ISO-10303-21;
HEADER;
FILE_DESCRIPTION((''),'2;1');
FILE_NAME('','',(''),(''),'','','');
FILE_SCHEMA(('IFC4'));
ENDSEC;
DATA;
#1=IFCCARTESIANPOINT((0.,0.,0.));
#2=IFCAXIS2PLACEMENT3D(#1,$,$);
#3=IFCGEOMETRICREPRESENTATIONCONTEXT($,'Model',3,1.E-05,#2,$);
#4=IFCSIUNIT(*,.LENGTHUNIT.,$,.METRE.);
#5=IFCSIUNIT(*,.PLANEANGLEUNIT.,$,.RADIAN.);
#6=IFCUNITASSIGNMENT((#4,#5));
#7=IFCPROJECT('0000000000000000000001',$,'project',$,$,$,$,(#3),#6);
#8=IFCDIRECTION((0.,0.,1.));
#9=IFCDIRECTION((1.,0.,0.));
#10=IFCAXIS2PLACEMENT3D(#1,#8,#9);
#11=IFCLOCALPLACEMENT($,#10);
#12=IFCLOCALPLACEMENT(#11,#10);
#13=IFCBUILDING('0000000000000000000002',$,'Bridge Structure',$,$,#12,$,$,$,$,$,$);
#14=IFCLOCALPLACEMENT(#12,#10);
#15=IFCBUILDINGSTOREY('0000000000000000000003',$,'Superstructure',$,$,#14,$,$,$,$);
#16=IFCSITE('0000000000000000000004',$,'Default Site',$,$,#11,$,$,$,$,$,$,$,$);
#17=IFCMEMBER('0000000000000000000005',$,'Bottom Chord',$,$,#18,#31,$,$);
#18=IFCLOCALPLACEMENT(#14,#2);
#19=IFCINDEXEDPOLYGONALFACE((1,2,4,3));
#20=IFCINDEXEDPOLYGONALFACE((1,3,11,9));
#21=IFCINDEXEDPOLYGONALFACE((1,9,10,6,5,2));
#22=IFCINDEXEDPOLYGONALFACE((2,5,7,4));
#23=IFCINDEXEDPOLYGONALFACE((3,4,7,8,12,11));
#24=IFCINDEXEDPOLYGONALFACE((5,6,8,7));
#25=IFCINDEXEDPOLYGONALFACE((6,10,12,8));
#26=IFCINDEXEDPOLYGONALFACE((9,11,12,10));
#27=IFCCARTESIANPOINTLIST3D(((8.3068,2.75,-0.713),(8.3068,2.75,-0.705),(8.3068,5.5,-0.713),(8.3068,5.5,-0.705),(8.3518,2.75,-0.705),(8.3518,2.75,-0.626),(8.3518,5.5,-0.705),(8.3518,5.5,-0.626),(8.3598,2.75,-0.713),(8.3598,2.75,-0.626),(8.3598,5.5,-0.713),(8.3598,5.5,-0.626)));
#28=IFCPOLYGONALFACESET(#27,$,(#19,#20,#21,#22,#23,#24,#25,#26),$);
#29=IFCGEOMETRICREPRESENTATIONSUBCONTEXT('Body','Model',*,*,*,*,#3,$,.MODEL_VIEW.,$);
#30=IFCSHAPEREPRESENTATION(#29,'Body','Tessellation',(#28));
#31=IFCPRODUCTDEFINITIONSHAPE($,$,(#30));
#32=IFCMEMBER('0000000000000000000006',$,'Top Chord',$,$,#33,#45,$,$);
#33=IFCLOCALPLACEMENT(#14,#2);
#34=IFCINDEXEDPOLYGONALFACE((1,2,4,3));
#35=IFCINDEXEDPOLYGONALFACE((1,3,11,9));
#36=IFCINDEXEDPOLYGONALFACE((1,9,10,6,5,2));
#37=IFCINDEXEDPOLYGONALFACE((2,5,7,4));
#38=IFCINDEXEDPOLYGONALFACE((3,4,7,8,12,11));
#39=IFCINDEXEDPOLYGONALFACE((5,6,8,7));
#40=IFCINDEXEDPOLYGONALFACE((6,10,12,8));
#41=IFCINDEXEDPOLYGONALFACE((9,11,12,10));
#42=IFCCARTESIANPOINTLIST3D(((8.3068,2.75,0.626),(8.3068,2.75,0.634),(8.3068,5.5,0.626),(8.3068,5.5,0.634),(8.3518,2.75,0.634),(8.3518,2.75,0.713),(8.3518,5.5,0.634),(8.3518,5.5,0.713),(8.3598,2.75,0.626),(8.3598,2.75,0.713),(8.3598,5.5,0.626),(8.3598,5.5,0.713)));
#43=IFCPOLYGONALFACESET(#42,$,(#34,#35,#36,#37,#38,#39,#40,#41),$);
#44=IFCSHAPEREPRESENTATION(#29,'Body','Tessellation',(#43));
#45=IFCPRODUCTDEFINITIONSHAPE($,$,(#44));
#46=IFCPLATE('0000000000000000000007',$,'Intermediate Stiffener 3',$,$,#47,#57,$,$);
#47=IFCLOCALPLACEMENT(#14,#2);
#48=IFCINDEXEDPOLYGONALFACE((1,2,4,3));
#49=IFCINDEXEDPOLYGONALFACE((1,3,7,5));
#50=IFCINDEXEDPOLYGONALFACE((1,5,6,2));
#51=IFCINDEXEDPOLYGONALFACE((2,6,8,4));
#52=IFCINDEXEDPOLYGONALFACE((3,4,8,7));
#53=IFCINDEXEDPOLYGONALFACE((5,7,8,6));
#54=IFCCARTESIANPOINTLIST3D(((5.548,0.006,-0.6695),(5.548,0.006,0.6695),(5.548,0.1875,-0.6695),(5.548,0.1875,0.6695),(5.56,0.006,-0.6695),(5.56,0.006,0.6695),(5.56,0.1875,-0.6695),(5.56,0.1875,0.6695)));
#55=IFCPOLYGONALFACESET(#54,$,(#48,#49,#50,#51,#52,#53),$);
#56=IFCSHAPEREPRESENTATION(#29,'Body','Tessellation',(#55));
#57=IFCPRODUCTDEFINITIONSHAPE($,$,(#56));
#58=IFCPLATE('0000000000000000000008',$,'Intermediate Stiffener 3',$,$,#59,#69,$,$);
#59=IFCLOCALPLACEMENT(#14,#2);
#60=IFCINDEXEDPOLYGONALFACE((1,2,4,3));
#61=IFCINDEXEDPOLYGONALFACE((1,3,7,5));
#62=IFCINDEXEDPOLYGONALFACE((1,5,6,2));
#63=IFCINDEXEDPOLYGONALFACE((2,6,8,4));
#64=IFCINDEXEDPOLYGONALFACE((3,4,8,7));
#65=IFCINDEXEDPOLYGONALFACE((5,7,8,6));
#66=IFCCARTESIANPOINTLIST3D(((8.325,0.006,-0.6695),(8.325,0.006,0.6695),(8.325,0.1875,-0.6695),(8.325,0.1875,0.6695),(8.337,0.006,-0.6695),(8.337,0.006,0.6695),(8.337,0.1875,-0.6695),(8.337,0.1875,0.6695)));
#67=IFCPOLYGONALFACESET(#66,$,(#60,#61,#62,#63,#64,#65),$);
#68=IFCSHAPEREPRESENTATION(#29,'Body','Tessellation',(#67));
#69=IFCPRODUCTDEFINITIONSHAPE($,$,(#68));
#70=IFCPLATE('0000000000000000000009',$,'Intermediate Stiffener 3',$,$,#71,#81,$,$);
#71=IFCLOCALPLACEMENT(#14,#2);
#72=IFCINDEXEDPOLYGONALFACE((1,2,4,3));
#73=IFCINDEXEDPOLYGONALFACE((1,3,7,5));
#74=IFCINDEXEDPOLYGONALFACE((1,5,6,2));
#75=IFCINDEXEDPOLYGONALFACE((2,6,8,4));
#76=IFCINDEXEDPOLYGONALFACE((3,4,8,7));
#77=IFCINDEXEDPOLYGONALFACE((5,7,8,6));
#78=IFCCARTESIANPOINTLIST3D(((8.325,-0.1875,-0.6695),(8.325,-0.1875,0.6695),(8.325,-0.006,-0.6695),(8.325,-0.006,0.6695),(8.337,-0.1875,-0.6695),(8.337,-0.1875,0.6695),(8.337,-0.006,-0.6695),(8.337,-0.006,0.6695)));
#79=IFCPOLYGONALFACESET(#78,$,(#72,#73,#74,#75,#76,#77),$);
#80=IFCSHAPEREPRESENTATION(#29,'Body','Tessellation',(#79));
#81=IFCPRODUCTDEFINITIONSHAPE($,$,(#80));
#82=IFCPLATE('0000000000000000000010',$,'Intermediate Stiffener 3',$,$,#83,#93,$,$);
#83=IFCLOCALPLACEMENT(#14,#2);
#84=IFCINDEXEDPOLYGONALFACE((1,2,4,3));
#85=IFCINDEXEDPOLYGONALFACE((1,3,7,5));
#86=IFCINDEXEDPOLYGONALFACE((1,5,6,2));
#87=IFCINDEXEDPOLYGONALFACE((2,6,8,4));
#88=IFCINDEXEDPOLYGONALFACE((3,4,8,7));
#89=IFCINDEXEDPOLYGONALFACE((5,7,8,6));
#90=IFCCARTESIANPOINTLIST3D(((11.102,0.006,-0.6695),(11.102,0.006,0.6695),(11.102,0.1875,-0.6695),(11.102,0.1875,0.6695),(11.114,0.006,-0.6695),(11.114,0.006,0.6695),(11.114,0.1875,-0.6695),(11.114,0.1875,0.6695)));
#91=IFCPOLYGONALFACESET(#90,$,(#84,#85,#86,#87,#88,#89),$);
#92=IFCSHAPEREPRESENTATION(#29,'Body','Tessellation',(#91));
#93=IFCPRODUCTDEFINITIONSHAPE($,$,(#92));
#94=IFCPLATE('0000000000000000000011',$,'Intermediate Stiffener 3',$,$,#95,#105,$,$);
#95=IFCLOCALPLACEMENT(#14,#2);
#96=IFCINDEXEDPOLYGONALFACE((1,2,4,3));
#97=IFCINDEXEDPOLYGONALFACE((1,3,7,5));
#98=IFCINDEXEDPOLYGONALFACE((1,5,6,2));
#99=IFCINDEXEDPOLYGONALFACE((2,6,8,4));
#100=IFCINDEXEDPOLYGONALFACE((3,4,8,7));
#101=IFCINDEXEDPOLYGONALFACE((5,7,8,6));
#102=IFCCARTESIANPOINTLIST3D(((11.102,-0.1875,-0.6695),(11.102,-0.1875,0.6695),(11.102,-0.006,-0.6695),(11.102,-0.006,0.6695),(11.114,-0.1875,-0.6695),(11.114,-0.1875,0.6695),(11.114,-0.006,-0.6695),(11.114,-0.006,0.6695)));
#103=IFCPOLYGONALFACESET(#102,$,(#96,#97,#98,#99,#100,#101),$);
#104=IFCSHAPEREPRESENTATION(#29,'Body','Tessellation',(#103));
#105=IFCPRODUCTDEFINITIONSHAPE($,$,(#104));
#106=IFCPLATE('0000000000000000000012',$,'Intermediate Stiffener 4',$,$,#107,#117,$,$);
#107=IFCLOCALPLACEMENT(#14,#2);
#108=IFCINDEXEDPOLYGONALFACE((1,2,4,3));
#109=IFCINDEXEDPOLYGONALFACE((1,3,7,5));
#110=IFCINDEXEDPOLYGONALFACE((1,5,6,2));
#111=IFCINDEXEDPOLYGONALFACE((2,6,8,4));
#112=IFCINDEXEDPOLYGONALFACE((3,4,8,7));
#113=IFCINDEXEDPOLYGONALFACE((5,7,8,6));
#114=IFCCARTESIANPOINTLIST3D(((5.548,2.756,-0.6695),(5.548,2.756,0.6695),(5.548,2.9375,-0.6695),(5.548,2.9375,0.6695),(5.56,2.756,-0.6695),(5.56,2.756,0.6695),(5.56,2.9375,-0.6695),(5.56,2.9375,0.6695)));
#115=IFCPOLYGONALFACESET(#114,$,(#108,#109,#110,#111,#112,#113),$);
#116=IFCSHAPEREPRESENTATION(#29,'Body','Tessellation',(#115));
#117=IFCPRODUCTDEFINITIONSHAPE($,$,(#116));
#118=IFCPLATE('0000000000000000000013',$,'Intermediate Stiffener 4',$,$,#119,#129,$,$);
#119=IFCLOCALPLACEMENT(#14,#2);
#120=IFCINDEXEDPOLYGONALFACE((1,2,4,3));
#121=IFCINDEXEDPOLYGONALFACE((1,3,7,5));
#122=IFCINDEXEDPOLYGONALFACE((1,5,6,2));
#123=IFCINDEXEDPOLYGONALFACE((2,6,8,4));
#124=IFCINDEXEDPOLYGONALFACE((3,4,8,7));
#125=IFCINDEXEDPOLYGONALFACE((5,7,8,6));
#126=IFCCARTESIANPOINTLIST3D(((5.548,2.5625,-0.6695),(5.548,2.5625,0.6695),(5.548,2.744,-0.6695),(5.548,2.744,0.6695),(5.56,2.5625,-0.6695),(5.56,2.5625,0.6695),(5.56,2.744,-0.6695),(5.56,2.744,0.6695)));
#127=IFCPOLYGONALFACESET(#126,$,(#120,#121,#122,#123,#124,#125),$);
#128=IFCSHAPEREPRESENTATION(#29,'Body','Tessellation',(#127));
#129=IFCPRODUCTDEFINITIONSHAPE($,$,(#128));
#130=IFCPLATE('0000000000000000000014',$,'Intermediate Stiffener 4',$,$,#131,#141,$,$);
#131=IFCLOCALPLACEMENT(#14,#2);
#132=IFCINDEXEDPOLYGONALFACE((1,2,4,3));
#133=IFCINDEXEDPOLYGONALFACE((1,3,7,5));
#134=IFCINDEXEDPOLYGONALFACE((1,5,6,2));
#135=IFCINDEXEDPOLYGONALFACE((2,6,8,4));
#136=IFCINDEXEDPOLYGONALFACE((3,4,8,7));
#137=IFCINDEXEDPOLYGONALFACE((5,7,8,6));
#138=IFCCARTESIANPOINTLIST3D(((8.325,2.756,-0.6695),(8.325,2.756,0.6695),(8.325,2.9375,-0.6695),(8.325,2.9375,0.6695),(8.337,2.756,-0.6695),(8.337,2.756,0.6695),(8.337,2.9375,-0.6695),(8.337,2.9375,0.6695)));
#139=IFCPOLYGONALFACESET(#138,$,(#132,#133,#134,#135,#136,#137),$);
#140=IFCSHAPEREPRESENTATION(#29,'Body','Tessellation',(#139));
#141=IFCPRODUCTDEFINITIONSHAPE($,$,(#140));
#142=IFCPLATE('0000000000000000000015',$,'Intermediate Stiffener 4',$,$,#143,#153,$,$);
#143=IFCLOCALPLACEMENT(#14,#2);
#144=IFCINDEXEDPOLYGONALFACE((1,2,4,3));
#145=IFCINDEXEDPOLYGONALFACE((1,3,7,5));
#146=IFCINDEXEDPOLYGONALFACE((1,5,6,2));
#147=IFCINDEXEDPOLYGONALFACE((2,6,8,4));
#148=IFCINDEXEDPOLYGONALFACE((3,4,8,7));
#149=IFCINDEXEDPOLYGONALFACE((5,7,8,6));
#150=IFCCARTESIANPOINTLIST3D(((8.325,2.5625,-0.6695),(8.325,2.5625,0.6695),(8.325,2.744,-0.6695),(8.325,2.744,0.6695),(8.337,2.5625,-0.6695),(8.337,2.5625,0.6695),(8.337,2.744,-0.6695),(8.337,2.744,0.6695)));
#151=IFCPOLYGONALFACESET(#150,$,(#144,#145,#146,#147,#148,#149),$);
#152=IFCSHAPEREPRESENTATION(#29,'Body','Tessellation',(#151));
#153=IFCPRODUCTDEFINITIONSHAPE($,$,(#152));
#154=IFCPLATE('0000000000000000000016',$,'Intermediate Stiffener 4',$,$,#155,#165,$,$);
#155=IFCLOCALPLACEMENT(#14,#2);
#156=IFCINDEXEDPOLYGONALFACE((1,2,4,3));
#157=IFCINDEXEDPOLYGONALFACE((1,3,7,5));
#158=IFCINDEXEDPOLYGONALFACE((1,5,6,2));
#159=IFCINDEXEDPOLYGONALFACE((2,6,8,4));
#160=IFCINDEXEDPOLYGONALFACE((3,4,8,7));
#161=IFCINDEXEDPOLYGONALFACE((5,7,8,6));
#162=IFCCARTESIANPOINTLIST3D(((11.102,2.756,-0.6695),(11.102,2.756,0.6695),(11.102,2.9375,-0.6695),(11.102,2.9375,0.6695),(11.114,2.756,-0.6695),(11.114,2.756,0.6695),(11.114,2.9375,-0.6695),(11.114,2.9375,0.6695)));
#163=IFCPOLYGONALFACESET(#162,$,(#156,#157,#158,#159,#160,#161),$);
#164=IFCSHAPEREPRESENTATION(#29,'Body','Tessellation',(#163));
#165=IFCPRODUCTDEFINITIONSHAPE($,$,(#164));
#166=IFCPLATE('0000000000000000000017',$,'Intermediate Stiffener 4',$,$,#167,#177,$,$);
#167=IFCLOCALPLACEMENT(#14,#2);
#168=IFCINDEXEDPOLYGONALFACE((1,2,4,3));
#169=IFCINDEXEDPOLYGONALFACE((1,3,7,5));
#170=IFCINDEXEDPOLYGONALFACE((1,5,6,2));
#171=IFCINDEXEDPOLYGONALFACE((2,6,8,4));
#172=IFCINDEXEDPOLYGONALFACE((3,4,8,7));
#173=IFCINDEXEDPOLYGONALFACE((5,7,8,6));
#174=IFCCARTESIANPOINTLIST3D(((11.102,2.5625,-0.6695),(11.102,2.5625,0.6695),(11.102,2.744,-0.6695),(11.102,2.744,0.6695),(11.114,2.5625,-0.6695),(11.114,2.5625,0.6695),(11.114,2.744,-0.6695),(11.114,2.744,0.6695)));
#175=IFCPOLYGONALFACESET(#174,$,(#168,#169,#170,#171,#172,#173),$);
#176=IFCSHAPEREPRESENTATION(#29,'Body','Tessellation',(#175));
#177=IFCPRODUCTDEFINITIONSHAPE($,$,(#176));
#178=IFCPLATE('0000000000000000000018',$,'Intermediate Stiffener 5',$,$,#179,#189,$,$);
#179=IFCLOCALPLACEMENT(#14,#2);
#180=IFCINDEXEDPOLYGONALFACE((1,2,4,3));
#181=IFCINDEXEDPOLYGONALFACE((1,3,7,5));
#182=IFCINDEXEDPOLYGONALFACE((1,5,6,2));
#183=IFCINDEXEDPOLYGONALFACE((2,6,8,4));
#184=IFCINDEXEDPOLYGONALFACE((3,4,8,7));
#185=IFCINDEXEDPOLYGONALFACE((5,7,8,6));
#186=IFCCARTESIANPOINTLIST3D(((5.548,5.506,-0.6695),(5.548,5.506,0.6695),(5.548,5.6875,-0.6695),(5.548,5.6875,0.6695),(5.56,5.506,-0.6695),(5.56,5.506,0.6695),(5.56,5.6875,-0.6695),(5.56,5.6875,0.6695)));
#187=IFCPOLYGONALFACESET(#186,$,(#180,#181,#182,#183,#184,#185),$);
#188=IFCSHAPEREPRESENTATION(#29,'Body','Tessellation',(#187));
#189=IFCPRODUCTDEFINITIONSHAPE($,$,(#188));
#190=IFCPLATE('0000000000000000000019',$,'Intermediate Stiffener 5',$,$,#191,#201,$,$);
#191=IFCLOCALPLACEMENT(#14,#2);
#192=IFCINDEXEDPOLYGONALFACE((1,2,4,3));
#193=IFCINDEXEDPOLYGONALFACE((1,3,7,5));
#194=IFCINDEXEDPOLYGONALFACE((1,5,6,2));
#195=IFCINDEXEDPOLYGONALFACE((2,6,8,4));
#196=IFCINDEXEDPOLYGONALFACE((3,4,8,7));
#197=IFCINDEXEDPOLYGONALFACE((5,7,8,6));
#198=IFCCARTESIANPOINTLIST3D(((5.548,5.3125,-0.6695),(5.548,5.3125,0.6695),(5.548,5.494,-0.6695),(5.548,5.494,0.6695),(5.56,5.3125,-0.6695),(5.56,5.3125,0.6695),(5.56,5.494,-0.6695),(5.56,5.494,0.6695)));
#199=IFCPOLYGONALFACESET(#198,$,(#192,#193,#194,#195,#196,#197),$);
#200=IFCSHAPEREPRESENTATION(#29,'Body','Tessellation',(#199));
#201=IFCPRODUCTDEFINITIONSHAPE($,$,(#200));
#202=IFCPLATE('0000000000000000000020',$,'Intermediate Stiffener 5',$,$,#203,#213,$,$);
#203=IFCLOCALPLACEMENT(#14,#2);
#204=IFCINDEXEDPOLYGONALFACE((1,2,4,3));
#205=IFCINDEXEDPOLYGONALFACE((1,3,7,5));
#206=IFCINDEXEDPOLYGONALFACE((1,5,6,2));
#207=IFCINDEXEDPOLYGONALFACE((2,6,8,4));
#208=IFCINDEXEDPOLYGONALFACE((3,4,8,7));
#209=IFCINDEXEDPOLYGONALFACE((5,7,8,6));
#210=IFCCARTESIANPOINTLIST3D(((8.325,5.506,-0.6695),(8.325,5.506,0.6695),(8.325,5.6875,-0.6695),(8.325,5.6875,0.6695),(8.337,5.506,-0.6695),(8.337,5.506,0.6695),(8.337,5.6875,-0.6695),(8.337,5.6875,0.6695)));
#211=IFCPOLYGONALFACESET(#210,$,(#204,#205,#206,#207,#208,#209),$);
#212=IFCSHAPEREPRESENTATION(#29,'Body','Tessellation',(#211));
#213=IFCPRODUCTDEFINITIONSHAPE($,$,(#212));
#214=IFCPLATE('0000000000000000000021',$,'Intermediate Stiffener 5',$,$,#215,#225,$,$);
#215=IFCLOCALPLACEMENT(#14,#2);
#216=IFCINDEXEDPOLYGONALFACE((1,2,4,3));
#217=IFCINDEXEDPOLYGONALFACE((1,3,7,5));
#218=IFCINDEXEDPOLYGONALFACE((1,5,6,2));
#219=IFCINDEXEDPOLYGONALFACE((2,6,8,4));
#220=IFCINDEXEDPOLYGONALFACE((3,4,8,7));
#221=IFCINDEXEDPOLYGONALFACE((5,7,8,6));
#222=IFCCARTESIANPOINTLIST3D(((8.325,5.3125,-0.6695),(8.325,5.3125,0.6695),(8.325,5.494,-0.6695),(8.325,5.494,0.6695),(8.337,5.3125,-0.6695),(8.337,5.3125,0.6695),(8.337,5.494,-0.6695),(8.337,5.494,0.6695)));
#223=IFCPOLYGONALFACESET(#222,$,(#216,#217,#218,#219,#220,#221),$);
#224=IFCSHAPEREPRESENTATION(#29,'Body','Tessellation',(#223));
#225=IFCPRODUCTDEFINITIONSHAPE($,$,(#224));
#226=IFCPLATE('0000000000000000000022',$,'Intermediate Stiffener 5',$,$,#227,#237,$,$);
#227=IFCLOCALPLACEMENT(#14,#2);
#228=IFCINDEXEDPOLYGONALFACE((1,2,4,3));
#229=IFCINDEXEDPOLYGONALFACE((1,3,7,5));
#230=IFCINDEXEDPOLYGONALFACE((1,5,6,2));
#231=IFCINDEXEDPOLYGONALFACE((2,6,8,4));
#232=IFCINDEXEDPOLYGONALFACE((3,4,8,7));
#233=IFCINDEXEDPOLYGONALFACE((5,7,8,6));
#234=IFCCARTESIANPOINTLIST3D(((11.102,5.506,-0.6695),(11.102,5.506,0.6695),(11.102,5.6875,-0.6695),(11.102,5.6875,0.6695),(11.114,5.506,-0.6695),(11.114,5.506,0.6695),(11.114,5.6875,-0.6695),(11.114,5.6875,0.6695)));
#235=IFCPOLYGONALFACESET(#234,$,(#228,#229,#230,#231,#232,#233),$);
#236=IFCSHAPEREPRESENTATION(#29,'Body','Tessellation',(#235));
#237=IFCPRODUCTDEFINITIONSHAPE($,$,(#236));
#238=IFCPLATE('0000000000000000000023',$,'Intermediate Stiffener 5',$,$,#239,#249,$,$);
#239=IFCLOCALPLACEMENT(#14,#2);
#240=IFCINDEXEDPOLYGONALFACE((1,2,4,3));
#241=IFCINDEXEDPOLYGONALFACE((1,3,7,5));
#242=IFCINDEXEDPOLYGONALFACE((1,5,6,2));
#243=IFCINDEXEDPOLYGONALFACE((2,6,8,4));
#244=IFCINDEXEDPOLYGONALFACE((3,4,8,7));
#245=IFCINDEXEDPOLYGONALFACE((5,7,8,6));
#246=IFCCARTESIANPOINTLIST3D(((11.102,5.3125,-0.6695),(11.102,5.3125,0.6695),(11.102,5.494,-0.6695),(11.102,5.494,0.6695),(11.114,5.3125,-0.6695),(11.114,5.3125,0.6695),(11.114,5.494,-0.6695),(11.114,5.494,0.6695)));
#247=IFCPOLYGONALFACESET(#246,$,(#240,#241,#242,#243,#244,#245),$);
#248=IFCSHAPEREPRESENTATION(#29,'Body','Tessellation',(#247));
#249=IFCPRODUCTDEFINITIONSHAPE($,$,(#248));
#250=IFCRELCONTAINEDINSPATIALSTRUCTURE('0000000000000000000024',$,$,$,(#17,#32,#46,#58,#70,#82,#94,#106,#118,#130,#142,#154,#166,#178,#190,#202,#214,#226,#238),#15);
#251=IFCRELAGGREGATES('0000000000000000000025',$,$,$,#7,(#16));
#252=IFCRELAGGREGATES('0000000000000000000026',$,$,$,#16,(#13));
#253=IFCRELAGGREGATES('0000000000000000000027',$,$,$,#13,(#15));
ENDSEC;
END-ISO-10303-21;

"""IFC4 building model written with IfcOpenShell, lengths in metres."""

from ifc_helpers import new_model, si_unit, frame, origin, origin_with_axes, origin_2d_with_axis, place, context, subcontext, project, spatial, rectangle, l_section, extrude, element, save


model = new_model("IFC4")

# Units and contexts
model_context = context("Model", 3, precision=1e-05, world=origin())
body_context = subcontext(model_context, "Body", "Model", "MODEL_VIEW")
ifc_project = project(units=[si_unit("LENGTHUNIT", "METRE"), si_unit("PLANEANGLEUNIT", "RADIAN")], contexts=[model_context])

# Site, building, storey
site_placement = place(None, origin_with_axes())
site = spatial("IfcSite", under=ifc_project, at=site_placement, Name="Default Site")
building_placement = place(site_placement, origin_with_axes())
building = spatial("IfcBuilding", under=site, at=building_placement, Name="Bridge Structure")
storey_placement = place(building_placement, origin_with_axes())
storey = spatial("IfcBuildingStorey", under=building, at=storey_placement, Name="Superstructure")

# Members
for number, where, z_axis, x_axis, name in (
    (1, (8.3333, 2.75, -0.6695), (0.0, 1.0, 0.0), (-1.0, 0.0, 0.0), "Bottom Chord"),
    (2, (8.3333, 2.75, 0.6695), (0.0, 1.0, 0.0), (-1.0, 0.0, 0.0), "Top Chord"),
):
    element("IfcMember", number, at=place(storey_placement, frame(where, z_axis=z_axis, x_axis=x_axis)), inside=storey, Name=name, context=body_context, shape_type="SweptSolid", body=[
        extrude(l_section(Depth=0.087, Width=0.053, Thickness=0.008, at=origin_2d_with_axis()), origin_with_axes(), (0.0, 0.0, 1.0), 2.75),
    ])

# Plates
for number, where, z_axis, x_axis, name in (
    (3, (5.554, 0.0968, -0.6695), (0.0, 0.0, 1.0), (1.0, 0.0, 0.0), "Intermediate Stiffener 3"),
    (4, (8.331, 0.0968, -0.6695), (0.0, 0.0, 1.0), (1.0, 0.0, 0.0), "Intermediate Stiffener 3"),
    (5, (8.331, -0.0968, -0.6695), (0.0, 0.0, 1.0), (1.0, 0.0, 0.0), "Intermediate Stiffener 3"),
    (6, (11.108, 0.0968, -0.6695), (0.0, 0.0, 1.0), (1.0, 0.0, 0.0), "Intermediate Stiffener 3"),
    (7, (11.108, -0.0968, -0.6695), (0.0, 0.0, 1.0), (1.0, 0.0, 0.0), "Intermediate Stiffener 3"),
    (8, (5.554, 2.8468, -0.6695), (0.0, 0.0, 1.0), (1.0, 0.0, 0.0), "Intermediate Stiffener 4"),
    (9, (5.554, 2.6532, -0.6695), (0.0, 0.0, 1.0), (1.0, 0.0, 0.0), "Intermediate Stiffener 4"),
    (10, (8.331, 2.8468, -0.6695), (0.0, 0.0, 1.0), (1.0, 0.0, 0.0), "Intermediate Stiffener 4"),
    (11, (8.331, 2.6532, -0.6695), (0.0, 0.0, 1.0), (1.0, 0.0, 0.0), "Intermediate Stiffener 4"),
    (12, (11.108, 2.8468, -0.6695), (0.0, 0.0, 1.0), (1.0, 0.0, 0.0), "Intermediate Stiffener 4"),
    (13, (11.108, 2.6532, -0.6695), (0.0, 0.0, 1.0), (1.0, 0.0, 0.0), "Intermediate Stiffener 4"),
    (14, (5.554, 5.5968, -0.6695), (0.0, 0.0, 1.0), (1.0, 0.0, 0.0), "Intermediate Stiffener 5"),
    (15, (5.554, 5.4032, -0.6695), (0.0, 0.0, 1.0), (1.0, 0.0, 0.0), "Intermediate Stiffener 5"),
    (16, (8.331, 5.5968, -0.6695), (0.0, 0.0, 1.0), (1.0, 0.0, 0.0), "Intermediate Stiffener 5"),
    (17, (8.331, 5.4032, -0.6695), (0.0, 0.0, 1.0), (1.0, 0.0, 0.0), "Intermediate Stiffener 5"),
    (18, (11.108, 5.5968, -0.6695), (0.0, 0.0, 1.0), (1.0, 0.0, 0.0), "Intermediate Stiffener 5"),
    (19, (11.108, 5.4032, -0.6695), (0.0, 0.0, 1.0), (1.0, 0.0, 0.0), "Intermediate Stiffener 5"),
):
    element("IfcPlate", number, at=place(storey_placement, frame(where, z_axis=z_axis, x_axis=x_axis)), inside=storey, Name=name, context=body_context, shape_type="SweptSolid", body=[
        extrude(rectangle(XDim=0.012, YDim=0.1815, at=origin_2d_with_axis()), origin_with_axes(), (0.0, 0.0, 1.0), 1.339),
    ])

save(model, "model.ifc")
